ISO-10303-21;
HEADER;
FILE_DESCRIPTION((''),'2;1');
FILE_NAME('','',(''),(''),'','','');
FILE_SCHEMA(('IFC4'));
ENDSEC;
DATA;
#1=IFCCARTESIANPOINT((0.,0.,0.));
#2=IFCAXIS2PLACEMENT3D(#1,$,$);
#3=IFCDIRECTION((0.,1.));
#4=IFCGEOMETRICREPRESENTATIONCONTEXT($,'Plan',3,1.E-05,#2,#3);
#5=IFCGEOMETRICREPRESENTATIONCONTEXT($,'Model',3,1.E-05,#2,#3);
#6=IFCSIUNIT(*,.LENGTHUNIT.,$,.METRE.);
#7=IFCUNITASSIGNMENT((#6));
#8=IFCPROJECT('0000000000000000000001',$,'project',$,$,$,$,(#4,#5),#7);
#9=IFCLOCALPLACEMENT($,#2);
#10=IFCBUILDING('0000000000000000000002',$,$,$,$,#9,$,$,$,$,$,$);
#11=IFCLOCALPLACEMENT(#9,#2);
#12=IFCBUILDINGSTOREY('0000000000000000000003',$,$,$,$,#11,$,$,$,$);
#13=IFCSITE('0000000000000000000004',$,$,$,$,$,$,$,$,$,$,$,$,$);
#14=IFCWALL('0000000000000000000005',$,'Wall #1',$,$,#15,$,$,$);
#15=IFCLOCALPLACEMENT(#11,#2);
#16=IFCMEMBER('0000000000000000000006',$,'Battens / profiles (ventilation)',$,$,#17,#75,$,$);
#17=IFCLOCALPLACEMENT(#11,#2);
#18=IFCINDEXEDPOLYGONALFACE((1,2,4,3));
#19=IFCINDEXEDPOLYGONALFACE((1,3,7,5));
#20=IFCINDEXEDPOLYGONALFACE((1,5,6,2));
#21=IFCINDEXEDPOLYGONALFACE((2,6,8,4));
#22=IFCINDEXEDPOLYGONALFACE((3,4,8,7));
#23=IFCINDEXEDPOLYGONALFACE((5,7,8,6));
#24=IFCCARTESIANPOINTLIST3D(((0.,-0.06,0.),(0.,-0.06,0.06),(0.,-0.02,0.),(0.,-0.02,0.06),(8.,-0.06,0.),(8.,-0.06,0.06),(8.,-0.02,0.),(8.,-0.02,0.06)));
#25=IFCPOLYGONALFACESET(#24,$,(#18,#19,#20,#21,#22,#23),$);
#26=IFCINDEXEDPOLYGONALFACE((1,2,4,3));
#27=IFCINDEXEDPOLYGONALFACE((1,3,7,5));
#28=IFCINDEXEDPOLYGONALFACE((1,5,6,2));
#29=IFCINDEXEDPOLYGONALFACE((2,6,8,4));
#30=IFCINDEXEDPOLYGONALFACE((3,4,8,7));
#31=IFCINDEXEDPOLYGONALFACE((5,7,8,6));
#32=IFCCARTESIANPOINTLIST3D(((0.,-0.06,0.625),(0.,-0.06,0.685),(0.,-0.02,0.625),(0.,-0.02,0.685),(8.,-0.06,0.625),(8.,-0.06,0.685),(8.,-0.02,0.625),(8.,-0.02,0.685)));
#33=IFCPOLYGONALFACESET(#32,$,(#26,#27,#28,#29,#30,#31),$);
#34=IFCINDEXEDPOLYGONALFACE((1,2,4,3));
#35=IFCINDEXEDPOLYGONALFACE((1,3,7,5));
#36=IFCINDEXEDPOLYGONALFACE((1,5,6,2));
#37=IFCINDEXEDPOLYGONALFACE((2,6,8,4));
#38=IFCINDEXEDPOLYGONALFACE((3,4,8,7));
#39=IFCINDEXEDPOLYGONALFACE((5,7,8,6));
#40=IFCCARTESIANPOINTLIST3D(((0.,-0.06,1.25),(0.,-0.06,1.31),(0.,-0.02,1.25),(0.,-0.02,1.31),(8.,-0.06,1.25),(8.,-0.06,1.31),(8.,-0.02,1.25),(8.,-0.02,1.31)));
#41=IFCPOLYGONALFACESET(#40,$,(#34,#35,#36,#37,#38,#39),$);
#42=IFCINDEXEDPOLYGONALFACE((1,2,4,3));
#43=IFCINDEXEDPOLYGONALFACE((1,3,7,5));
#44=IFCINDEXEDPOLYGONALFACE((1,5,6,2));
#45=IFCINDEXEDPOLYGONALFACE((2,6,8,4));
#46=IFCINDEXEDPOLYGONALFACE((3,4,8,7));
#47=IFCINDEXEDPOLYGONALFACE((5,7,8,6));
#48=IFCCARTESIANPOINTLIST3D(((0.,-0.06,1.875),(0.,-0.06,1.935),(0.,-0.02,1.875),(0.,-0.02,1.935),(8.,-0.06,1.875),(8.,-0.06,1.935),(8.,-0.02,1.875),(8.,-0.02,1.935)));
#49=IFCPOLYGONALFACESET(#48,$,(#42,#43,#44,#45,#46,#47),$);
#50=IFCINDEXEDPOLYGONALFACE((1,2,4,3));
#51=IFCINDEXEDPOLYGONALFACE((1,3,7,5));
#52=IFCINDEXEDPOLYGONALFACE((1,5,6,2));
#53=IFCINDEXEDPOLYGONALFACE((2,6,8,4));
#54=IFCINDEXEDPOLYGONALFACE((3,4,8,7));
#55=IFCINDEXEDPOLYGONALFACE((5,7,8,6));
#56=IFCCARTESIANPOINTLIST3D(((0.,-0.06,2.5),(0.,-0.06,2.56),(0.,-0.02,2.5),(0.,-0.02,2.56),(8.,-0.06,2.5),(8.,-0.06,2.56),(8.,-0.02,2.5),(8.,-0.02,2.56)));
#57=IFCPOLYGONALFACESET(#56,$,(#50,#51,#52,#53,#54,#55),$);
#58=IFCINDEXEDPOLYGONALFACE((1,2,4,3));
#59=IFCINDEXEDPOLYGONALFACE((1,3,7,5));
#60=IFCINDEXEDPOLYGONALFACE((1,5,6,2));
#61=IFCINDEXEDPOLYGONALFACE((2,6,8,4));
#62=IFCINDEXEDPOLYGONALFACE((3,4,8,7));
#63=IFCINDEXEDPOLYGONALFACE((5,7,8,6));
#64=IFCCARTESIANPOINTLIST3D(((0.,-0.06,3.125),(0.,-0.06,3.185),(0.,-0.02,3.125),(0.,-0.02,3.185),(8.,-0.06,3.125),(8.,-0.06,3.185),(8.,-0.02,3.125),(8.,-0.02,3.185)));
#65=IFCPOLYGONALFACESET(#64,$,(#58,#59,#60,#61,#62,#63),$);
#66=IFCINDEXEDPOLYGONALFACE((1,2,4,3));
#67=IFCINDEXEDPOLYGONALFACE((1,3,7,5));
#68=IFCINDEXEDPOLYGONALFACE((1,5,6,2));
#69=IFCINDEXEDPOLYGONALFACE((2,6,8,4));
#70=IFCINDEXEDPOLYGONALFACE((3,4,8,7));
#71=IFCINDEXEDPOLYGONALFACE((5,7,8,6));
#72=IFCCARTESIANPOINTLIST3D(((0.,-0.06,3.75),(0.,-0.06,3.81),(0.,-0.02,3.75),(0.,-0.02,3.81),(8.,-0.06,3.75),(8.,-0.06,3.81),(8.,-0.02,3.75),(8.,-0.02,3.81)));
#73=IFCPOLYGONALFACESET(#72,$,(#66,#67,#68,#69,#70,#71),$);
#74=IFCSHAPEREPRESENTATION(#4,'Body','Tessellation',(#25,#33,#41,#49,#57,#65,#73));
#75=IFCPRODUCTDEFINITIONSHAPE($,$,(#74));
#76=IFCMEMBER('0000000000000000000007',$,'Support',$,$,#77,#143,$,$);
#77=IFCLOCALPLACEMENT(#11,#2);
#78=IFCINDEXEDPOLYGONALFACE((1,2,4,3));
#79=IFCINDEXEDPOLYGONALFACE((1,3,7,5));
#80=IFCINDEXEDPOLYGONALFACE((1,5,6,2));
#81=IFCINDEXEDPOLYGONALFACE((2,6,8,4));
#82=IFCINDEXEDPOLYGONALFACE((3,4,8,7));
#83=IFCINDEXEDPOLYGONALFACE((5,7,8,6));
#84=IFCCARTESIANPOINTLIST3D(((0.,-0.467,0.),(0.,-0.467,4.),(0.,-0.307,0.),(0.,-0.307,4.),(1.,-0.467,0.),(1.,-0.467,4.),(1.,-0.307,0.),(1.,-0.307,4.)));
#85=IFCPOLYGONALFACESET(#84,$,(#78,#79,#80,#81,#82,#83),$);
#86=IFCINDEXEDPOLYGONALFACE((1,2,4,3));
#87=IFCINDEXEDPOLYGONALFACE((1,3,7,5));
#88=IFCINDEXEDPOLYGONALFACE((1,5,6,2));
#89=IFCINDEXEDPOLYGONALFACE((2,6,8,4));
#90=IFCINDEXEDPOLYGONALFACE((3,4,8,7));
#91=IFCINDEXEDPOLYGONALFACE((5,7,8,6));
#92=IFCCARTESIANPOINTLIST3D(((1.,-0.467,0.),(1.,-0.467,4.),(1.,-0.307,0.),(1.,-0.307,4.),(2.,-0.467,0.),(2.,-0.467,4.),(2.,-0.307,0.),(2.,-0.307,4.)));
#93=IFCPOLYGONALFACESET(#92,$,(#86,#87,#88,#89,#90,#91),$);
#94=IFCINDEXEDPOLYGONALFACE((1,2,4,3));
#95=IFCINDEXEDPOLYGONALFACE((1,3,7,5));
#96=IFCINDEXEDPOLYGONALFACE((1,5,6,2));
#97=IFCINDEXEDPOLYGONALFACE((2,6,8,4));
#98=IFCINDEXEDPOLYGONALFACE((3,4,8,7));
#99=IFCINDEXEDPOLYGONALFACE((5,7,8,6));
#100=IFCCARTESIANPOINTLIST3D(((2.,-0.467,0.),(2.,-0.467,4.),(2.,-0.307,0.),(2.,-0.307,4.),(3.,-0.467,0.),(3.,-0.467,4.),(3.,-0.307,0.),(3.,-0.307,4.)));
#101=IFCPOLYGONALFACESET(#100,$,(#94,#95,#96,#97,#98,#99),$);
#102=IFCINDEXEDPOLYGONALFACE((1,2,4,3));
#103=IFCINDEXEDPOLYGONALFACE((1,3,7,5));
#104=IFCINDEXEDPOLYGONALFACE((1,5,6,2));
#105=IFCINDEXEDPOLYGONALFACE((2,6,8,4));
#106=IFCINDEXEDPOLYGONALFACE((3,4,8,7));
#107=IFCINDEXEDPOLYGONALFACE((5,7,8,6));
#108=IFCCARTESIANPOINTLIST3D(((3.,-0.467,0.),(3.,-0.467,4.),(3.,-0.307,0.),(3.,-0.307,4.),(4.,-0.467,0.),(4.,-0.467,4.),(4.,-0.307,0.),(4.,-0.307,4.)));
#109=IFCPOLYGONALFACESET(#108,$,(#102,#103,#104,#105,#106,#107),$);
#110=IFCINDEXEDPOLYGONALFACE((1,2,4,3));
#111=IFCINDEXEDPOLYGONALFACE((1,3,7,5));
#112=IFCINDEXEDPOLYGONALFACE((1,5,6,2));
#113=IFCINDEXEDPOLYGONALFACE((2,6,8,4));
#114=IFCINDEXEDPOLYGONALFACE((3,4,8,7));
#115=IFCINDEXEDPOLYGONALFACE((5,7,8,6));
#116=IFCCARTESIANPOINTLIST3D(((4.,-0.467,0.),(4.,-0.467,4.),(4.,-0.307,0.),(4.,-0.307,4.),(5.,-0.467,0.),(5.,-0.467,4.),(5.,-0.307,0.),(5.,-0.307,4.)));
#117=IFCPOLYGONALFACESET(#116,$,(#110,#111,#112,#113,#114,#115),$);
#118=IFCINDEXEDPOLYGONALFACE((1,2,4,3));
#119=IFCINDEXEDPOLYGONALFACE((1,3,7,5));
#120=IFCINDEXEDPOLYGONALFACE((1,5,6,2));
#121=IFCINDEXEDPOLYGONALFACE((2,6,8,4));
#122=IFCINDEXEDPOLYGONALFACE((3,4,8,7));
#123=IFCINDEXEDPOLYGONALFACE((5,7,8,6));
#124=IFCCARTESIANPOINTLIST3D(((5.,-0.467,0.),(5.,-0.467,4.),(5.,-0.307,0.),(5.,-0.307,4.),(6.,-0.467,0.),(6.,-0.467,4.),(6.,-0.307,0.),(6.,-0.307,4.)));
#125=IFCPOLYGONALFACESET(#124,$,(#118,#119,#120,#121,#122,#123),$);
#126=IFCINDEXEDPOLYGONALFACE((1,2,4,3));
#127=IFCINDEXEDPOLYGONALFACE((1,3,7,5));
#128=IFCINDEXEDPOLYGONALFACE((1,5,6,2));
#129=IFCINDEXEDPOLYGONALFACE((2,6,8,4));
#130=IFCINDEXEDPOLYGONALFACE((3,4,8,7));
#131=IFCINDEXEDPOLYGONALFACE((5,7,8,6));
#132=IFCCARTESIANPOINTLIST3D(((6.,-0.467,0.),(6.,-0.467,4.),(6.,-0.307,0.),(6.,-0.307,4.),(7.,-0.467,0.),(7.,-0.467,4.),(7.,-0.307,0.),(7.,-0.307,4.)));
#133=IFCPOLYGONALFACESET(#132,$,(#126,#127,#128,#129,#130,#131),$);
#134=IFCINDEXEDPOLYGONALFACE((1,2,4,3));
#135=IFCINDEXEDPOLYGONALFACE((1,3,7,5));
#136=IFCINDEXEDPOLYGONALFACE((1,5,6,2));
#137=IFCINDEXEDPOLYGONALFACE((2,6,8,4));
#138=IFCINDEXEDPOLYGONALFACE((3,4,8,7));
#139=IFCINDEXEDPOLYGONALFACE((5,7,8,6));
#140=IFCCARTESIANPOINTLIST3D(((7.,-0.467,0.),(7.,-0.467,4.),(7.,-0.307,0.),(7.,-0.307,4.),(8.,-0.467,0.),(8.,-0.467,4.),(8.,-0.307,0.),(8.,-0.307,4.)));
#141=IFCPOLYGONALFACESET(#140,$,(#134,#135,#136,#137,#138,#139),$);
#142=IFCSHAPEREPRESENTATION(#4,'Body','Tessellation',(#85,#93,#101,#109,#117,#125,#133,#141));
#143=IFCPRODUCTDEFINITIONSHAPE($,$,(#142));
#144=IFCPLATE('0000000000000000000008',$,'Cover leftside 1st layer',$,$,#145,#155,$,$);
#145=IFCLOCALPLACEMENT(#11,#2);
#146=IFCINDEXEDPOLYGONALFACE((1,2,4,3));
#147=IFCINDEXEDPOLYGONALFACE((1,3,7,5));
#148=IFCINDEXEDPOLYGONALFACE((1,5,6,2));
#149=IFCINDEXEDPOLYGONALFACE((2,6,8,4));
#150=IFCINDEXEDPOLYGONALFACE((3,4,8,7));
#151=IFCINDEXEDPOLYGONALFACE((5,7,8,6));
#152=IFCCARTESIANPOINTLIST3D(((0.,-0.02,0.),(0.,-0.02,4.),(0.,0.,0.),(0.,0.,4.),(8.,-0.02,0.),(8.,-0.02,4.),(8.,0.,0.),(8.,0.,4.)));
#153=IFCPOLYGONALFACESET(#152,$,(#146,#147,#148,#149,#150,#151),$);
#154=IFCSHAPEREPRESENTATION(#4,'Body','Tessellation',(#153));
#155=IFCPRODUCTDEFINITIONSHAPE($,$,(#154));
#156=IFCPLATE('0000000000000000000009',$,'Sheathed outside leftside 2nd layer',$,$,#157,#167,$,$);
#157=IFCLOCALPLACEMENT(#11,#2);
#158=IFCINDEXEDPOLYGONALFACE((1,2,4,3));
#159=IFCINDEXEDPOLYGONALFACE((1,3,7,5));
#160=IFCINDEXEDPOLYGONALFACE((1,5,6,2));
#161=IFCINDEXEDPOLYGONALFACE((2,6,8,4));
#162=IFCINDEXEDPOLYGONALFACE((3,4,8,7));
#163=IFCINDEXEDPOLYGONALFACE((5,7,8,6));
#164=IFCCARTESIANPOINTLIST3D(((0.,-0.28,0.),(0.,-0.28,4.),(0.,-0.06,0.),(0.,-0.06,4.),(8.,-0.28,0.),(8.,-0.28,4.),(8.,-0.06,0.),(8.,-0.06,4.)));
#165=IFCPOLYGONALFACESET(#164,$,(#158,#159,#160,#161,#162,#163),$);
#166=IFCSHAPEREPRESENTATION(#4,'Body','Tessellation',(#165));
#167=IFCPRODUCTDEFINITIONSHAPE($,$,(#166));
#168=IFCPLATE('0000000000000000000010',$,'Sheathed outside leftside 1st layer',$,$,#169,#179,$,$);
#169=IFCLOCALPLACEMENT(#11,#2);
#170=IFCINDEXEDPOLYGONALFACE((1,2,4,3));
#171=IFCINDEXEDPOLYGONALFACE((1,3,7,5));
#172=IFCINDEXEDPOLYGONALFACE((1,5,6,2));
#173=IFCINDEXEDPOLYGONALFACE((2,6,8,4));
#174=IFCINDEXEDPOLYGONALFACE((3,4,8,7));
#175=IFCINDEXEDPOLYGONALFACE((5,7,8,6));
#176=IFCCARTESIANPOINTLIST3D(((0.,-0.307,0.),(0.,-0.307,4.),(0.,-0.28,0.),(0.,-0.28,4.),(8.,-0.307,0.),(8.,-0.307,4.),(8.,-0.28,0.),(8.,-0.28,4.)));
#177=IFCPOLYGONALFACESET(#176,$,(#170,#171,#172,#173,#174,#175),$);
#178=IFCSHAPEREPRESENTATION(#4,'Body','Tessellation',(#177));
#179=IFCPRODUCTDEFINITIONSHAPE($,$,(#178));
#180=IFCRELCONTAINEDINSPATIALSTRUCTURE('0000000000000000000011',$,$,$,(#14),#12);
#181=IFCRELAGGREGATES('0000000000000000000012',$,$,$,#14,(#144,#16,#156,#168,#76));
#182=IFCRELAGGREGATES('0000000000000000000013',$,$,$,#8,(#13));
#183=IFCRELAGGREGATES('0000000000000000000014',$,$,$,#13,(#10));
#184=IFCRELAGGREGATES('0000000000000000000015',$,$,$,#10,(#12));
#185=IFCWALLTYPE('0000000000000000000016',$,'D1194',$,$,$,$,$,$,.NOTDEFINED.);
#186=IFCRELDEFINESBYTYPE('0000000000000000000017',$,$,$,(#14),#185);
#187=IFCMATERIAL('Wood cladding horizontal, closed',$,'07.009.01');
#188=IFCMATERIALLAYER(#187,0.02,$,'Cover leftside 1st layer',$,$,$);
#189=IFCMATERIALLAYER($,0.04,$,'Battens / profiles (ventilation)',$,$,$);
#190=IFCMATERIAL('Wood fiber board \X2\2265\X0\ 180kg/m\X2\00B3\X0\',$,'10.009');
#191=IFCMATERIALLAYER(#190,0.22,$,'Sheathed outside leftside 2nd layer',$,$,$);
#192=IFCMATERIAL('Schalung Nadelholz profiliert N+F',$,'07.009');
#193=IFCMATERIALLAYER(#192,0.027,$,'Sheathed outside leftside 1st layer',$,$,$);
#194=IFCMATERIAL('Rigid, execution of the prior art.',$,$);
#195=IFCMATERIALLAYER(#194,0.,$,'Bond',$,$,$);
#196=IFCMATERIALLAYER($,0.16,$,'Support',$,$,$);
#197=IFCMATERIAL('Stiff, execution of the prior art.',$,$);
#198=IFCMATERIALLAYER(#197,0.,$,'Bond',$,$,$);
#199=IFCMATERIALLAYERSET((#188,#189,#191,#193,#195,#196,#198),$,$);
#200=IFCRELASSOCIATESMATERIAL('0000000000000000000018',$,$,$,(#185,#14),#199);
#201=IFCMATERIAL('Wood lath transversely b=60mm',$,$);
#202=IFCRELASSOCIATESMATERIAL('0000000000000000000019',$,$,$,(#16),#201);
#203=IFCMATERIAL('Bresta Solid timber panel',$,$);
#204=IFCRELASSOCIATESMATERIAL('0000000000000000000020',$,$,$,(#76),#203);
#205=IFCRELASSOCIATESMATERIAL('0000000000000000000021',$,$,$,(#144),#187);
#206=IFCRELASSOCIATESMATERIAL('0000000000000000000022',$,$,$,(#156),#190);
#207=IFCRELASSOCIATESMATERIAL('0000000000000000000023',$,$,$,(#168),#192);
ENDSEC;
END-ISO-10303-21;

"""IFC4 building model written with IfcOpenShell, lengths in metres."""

from ifc_helpers import new_model, si_unit, direction, frame, frame_2d, origin, origin_with_axes, place, context, project, spatial, rectangle, extrude, material, layer, layer_set, type_object, element, aggregate, save


model = new_model("IFC4")

# Units and contexts
plan_context = context("Plan", 3, precision=1e-05, world=origin(), true_north=direction((0.0, 1.0)))
model_context = context("Model", 3, precision=1e-05, world=origin(), true_north=direction((0.0, 1.0)))
ifc_project = project(units=[si_unit("LENGTHUNIT", "METRE")], contexts=[plan_context, model_context])

# Site, building, storey
site = spatial("IfcSite", under=ifc_project)
building_placement = place(None, origin())
building = spatial("IfcBuilding", under=site, at=building_placement)
storey_placement = place(building_placement, origin())
storey = spatial("IfcBuildingStorey", under=building, at=storey_placement)

# Wall, members, plates
ifc_material_1 = material(Name="Wood cladding horizontal, closed", Category="07.009.01")
ifc_layer_1 = layer(ifc_material_1, 0.02, Name="Cover leftside 1st layer")
ifc_layer_2 = layer(None, 0.04, Name="Battens / profiles (ventilation)")
ifc_material_2 = material(Name="Wood fiber board ≥ 180kg/m³", Category="10.009")
ifc_layer_3 = layer(ifc_material_2, 0.22, Name="Sheathed outside leftside 2nd layer")
ifc_material_3 = material(Name="Schalung Nadelholz profiliert N+F", Category="07.009")
ifc_layer_4 = layer(ifc_material_3, 0.027, Name="Sheathed outside leftside 1st layer")
ifc_material_4 = material(Name="Rigid, execution of the prior art.")
ifc_layer_5 = layer(ifc_material_4, 0.0, Name="Bond")
ifc_layer_6 = layer(None, 0.16, Name="Support")
ifc_material_5 = material(Name="Stiff, execution of the prior art.")
ifc_layer_7 = layer(ifc_material_5, 0.0, Name="Bond")
ifc_layer_set = layer_set([ifc_layer_1, ifc_layer_2, ifc_layer_3, ifc_layer_4, ifc_layer_5, ifc_layer_6, ifc_layer_7])
wall_type = type_object("IfcWallType", Name="D1194", PredefinedType="NOTDEFINED", material=ifc_layer_set)
wall_placement = place(None, frame((0.0, 0.0, 0.0), z_axis=(0.0, -1.0, 0.0), x_axis=(1.0, 0.0, 0.0)))
wall = element("IfcWall", 1, at=wall_placement, inside=storey, type_object=wall_type, material=ifc_layer_set, Name="Wall #1")
ifc_material_6 = material(Name="Wood lath transversely b=60mm")
member_1_placement = place(wall_placement, origin())
member_1 = element("IfcMember", 2, at=member_1_placement, material=ifc_material_6, Name="Battens / profiles (ventilation)", context=plan_context, shape_type="SweptSolid", body=[
    extrude(rectangle(XDim=0.06, YDim=0.04, at=frame_2d((0.03, 0.02), x_axis=(1.0, 0.0))), frame((0.0, 0.0, 0.02), z_axis=(1.0, 0.0, 0.0), x_axis=(0.0, 1.0, 0.0)), (0.0, 0.0, 1.0), 8.0),
    extrude(rectangle(XDim=0.06, YDim=0.04, at=frame_2d((0.03, 0.02), x_axis=(1.0, 0.0))), frame((0.0, 0.625, 0.02), z_axis=(1.0, 0.0, 0.0), x_axis=(0.0, 1.0, 0.0)), (0.0, 0.0, 1.0), 8.0),
    extrude(rectangle(XDim=0.06, YDim=0.04, at=frame_2d((0.03, 0.02), x_axis=(1.0, 0.0))), frame((0.0, 1.25, 0.02), z_axis=(1.0, 0.0, 0.0), x_axis=(0.0, 1.0, 0.0)), (0.0, 0.0, 1.0), 8.0),
    extrude(rectangle(XDim=0.06, YDim=0.04, at=frame_2d((0.03, 0.02), x_axis=(1.0, 0.0))), frame((0.0, 1.875, 0.02), z_axis=(1.0, 0.0, 0.0), x_axis=(0.0, 1.0, 0.0)), (0.0, 0.0, 1.0), 8.0),
    extrude(rectangle(XDim=0.06, YDim=0.04, at=frame_2d((0.03, 0.02), x_axis=(1.0, 0.0))), frame((0.0, 2.5, 0.02), z_axis=(1.0, 0.0, 0.0), x_axis=(0.0, 1.0, 0.0)), (0.0, 0.0, 1.0), 8.0),
    extrude(rectangle(XDim=0.06, YDim=0.04, at=frame_2d((0.03, 0.02), x_axis=(1.0, 0.0))), frame((0.0, 3.125, 0.02), z_axis=(1.0, 0.0, 0.0), x_axis=(0.0, 1.0, 0.0)), (0.0, 0.0, 1.0), 8.0),
    extrude(rectangle(XDim=0.06, YDim=0.04, at=frame_2d((0.03, 0.02), x_axis=(1.0, 0.0))), frame((0.0, 3.75, 0.02), z_axis=(1.0, 0.0, 0.0), x_axis=(0.0, 1.0, 0.0)), (0.0, 0.0, 1.0), 8.0),
])
ifc_material_7 = material(Name="Bresta Solid timber panel")
member_2_placement = place(wall_placement, origin())
member_2 = element("IfcMember", 3, at=member_2_placement, material=ifc_material_7, Name="Support", context=plan_context, shape_type="SweptSolid", body=[
    extrude(rectangle(XDim=1.0, YDim=0.16, at=frame_2d((0.5, 0.08), x_axis=(1.0, 0.0))), frame((0.0, 4.0, 0.307), z_axis=(0.0, -1.0, 0.0), x_axis=(1.0, 0.0, 0.0)), (0.0, 0.0, 1.0), 4.0),
    extrude(rectangle(XDim=1.0, YDim=0.16, at=frame_2d((0.5, 0.08), x_axis=(1.0, 0.0))), frame((1.0, 4.0, 0.307), z_axis=(0.0, -1.0, 0.0), x_axis=(1.0, 0.0, 0.0)), (0.0, 0.0, 1.0), 4.0),
    extrude(rectangle(XDim=1.0, YDim=0.16, at=frame_2d((0.5, 0.08), x_axis=(1.0, 0.0))), frame((2.0, 4.0, 0.307), z_axis=(0.0, -1.0, 0.0), x_axis=(1.0, 0.0, 0.0)), (0.0, 0.0, 1.0), 4.0),
    extrude(rectangle(XDim=1.0, YDim=0.16, at=frame_2d((0.5, 0.08), x_axis=(1.0, 0.0))), frame((3.0, 4.0, 0.307), z_axis=(0.0, -1.0, 0.0), x_axis=(1.0, 0.0, 0.0)), (0.0, 0.0, 1.0), 4.0),
    extrude(rectangle(XDim=1.0, YDim=0.16, at=frame_2d((0.5, 0.08), x_axis=(1.0, 0.0))), frame((4.0, 4.0, 0.307), z_axis=(0.0, -1.0, 0.0), x_axis=(1.0, 0.0, 0.0)), (0.0, 0.0, 1.0), 4.0),
    extrude(rectangle(XDim=1.0, YDim=0.16, at=frame_2d((0.5, 0.08), x_axis=(1.0, 0.0))), frame((5.0, 4.0, 0.307), z_axis=(0.0, -1.0, 0.0), x_axis=(1.0, 0.0, 0.0)), (0.0, 0.0, 1.0), 4.0),
    extrude(rectangle(XDim=1.0, YDim=0.16, at=frame_2d((0.5, 0.08), x_axis=(1.0, 0.0))), frame((6.0, 4.0, 0.307), z_axis=(0.0, -1.0, 0.0), x_axis=(1.0, 0.0, 0.0)), (0.0, 0.0, 1.0), 4.0),
    extrude(rectangle(XDim=1.0, YDim=0.16, at=frame_2d((0.5, 0.08), x_axis=(1.0, 0.0))), frame((7.0, 4.0, 0.307), z_axis=(0.0, -1.0, 0.0), x_axis=(1.0, 0.0, 0.0)), (0.0, 0.0, 1.0), 4.0),
])
plate_1_placement = place(wall_placement, origin())
plate_1 = element("IfcPlate", 4, at=plate_1_placement, material=ifc_material_1, Name="Cover leftside 1st layer", context=plan_context, shape_type="SweptSolid", body=[
    extrude(rectangle(XDim=8.0, YDim=4.0, at=frame_2d((4.0, 2.0), x_axis=(1.0, 0.0))), origin_with_axes(), (0.0, 0.0, 1.0), 0.02),
])
plate_2_placement = place(wall_placement, origin())
plate_2 = element("IfcPlate", 5, at=plate_2_placement, material=ifc_material_2, Name="Sheathed outside leftside 2nd layer", context=plan_context, shape_type="SweptSolid", body=[
    extrude(rectangle(XDim=8.0, YDim=4.0, at=frame_2d((4.0, 2.0), x_axis=(1.0, 0.0))), frame((0.0, 0.0, 0.06), z_axis=(0.0, 0.0, 1.0), x_axis=(1.0, 0.0, 0.0)), (0.0, 0.0, 1.0), 0.22),
])
plate_3_placement = place(wall_placement, origin())
plate_3 = element("IfcPlate", 6, at=plate_3_placement, material=ifc_material_3, Name="Sheathed outside leftside 1st layer", context=plan_context, shape_type="SweptSolid", body=[
    extrude(rectangle(XDim=8.0, YDim=4.0, at=frame_2d((4.0, 2.0), x_axis=(1.0, 0.0))), frame((0.0, 0.0, 0.28), z_axis=(0.0, 0.0, 1.0), x_axis=(1.0, 0.0, 0.0)), (0.0, 0.0, 1.0), 0.027),
])
aggregate(wall, [plate_1, member_1, plate_2, plate_3, member_2])

save(model, "model.ifc")
